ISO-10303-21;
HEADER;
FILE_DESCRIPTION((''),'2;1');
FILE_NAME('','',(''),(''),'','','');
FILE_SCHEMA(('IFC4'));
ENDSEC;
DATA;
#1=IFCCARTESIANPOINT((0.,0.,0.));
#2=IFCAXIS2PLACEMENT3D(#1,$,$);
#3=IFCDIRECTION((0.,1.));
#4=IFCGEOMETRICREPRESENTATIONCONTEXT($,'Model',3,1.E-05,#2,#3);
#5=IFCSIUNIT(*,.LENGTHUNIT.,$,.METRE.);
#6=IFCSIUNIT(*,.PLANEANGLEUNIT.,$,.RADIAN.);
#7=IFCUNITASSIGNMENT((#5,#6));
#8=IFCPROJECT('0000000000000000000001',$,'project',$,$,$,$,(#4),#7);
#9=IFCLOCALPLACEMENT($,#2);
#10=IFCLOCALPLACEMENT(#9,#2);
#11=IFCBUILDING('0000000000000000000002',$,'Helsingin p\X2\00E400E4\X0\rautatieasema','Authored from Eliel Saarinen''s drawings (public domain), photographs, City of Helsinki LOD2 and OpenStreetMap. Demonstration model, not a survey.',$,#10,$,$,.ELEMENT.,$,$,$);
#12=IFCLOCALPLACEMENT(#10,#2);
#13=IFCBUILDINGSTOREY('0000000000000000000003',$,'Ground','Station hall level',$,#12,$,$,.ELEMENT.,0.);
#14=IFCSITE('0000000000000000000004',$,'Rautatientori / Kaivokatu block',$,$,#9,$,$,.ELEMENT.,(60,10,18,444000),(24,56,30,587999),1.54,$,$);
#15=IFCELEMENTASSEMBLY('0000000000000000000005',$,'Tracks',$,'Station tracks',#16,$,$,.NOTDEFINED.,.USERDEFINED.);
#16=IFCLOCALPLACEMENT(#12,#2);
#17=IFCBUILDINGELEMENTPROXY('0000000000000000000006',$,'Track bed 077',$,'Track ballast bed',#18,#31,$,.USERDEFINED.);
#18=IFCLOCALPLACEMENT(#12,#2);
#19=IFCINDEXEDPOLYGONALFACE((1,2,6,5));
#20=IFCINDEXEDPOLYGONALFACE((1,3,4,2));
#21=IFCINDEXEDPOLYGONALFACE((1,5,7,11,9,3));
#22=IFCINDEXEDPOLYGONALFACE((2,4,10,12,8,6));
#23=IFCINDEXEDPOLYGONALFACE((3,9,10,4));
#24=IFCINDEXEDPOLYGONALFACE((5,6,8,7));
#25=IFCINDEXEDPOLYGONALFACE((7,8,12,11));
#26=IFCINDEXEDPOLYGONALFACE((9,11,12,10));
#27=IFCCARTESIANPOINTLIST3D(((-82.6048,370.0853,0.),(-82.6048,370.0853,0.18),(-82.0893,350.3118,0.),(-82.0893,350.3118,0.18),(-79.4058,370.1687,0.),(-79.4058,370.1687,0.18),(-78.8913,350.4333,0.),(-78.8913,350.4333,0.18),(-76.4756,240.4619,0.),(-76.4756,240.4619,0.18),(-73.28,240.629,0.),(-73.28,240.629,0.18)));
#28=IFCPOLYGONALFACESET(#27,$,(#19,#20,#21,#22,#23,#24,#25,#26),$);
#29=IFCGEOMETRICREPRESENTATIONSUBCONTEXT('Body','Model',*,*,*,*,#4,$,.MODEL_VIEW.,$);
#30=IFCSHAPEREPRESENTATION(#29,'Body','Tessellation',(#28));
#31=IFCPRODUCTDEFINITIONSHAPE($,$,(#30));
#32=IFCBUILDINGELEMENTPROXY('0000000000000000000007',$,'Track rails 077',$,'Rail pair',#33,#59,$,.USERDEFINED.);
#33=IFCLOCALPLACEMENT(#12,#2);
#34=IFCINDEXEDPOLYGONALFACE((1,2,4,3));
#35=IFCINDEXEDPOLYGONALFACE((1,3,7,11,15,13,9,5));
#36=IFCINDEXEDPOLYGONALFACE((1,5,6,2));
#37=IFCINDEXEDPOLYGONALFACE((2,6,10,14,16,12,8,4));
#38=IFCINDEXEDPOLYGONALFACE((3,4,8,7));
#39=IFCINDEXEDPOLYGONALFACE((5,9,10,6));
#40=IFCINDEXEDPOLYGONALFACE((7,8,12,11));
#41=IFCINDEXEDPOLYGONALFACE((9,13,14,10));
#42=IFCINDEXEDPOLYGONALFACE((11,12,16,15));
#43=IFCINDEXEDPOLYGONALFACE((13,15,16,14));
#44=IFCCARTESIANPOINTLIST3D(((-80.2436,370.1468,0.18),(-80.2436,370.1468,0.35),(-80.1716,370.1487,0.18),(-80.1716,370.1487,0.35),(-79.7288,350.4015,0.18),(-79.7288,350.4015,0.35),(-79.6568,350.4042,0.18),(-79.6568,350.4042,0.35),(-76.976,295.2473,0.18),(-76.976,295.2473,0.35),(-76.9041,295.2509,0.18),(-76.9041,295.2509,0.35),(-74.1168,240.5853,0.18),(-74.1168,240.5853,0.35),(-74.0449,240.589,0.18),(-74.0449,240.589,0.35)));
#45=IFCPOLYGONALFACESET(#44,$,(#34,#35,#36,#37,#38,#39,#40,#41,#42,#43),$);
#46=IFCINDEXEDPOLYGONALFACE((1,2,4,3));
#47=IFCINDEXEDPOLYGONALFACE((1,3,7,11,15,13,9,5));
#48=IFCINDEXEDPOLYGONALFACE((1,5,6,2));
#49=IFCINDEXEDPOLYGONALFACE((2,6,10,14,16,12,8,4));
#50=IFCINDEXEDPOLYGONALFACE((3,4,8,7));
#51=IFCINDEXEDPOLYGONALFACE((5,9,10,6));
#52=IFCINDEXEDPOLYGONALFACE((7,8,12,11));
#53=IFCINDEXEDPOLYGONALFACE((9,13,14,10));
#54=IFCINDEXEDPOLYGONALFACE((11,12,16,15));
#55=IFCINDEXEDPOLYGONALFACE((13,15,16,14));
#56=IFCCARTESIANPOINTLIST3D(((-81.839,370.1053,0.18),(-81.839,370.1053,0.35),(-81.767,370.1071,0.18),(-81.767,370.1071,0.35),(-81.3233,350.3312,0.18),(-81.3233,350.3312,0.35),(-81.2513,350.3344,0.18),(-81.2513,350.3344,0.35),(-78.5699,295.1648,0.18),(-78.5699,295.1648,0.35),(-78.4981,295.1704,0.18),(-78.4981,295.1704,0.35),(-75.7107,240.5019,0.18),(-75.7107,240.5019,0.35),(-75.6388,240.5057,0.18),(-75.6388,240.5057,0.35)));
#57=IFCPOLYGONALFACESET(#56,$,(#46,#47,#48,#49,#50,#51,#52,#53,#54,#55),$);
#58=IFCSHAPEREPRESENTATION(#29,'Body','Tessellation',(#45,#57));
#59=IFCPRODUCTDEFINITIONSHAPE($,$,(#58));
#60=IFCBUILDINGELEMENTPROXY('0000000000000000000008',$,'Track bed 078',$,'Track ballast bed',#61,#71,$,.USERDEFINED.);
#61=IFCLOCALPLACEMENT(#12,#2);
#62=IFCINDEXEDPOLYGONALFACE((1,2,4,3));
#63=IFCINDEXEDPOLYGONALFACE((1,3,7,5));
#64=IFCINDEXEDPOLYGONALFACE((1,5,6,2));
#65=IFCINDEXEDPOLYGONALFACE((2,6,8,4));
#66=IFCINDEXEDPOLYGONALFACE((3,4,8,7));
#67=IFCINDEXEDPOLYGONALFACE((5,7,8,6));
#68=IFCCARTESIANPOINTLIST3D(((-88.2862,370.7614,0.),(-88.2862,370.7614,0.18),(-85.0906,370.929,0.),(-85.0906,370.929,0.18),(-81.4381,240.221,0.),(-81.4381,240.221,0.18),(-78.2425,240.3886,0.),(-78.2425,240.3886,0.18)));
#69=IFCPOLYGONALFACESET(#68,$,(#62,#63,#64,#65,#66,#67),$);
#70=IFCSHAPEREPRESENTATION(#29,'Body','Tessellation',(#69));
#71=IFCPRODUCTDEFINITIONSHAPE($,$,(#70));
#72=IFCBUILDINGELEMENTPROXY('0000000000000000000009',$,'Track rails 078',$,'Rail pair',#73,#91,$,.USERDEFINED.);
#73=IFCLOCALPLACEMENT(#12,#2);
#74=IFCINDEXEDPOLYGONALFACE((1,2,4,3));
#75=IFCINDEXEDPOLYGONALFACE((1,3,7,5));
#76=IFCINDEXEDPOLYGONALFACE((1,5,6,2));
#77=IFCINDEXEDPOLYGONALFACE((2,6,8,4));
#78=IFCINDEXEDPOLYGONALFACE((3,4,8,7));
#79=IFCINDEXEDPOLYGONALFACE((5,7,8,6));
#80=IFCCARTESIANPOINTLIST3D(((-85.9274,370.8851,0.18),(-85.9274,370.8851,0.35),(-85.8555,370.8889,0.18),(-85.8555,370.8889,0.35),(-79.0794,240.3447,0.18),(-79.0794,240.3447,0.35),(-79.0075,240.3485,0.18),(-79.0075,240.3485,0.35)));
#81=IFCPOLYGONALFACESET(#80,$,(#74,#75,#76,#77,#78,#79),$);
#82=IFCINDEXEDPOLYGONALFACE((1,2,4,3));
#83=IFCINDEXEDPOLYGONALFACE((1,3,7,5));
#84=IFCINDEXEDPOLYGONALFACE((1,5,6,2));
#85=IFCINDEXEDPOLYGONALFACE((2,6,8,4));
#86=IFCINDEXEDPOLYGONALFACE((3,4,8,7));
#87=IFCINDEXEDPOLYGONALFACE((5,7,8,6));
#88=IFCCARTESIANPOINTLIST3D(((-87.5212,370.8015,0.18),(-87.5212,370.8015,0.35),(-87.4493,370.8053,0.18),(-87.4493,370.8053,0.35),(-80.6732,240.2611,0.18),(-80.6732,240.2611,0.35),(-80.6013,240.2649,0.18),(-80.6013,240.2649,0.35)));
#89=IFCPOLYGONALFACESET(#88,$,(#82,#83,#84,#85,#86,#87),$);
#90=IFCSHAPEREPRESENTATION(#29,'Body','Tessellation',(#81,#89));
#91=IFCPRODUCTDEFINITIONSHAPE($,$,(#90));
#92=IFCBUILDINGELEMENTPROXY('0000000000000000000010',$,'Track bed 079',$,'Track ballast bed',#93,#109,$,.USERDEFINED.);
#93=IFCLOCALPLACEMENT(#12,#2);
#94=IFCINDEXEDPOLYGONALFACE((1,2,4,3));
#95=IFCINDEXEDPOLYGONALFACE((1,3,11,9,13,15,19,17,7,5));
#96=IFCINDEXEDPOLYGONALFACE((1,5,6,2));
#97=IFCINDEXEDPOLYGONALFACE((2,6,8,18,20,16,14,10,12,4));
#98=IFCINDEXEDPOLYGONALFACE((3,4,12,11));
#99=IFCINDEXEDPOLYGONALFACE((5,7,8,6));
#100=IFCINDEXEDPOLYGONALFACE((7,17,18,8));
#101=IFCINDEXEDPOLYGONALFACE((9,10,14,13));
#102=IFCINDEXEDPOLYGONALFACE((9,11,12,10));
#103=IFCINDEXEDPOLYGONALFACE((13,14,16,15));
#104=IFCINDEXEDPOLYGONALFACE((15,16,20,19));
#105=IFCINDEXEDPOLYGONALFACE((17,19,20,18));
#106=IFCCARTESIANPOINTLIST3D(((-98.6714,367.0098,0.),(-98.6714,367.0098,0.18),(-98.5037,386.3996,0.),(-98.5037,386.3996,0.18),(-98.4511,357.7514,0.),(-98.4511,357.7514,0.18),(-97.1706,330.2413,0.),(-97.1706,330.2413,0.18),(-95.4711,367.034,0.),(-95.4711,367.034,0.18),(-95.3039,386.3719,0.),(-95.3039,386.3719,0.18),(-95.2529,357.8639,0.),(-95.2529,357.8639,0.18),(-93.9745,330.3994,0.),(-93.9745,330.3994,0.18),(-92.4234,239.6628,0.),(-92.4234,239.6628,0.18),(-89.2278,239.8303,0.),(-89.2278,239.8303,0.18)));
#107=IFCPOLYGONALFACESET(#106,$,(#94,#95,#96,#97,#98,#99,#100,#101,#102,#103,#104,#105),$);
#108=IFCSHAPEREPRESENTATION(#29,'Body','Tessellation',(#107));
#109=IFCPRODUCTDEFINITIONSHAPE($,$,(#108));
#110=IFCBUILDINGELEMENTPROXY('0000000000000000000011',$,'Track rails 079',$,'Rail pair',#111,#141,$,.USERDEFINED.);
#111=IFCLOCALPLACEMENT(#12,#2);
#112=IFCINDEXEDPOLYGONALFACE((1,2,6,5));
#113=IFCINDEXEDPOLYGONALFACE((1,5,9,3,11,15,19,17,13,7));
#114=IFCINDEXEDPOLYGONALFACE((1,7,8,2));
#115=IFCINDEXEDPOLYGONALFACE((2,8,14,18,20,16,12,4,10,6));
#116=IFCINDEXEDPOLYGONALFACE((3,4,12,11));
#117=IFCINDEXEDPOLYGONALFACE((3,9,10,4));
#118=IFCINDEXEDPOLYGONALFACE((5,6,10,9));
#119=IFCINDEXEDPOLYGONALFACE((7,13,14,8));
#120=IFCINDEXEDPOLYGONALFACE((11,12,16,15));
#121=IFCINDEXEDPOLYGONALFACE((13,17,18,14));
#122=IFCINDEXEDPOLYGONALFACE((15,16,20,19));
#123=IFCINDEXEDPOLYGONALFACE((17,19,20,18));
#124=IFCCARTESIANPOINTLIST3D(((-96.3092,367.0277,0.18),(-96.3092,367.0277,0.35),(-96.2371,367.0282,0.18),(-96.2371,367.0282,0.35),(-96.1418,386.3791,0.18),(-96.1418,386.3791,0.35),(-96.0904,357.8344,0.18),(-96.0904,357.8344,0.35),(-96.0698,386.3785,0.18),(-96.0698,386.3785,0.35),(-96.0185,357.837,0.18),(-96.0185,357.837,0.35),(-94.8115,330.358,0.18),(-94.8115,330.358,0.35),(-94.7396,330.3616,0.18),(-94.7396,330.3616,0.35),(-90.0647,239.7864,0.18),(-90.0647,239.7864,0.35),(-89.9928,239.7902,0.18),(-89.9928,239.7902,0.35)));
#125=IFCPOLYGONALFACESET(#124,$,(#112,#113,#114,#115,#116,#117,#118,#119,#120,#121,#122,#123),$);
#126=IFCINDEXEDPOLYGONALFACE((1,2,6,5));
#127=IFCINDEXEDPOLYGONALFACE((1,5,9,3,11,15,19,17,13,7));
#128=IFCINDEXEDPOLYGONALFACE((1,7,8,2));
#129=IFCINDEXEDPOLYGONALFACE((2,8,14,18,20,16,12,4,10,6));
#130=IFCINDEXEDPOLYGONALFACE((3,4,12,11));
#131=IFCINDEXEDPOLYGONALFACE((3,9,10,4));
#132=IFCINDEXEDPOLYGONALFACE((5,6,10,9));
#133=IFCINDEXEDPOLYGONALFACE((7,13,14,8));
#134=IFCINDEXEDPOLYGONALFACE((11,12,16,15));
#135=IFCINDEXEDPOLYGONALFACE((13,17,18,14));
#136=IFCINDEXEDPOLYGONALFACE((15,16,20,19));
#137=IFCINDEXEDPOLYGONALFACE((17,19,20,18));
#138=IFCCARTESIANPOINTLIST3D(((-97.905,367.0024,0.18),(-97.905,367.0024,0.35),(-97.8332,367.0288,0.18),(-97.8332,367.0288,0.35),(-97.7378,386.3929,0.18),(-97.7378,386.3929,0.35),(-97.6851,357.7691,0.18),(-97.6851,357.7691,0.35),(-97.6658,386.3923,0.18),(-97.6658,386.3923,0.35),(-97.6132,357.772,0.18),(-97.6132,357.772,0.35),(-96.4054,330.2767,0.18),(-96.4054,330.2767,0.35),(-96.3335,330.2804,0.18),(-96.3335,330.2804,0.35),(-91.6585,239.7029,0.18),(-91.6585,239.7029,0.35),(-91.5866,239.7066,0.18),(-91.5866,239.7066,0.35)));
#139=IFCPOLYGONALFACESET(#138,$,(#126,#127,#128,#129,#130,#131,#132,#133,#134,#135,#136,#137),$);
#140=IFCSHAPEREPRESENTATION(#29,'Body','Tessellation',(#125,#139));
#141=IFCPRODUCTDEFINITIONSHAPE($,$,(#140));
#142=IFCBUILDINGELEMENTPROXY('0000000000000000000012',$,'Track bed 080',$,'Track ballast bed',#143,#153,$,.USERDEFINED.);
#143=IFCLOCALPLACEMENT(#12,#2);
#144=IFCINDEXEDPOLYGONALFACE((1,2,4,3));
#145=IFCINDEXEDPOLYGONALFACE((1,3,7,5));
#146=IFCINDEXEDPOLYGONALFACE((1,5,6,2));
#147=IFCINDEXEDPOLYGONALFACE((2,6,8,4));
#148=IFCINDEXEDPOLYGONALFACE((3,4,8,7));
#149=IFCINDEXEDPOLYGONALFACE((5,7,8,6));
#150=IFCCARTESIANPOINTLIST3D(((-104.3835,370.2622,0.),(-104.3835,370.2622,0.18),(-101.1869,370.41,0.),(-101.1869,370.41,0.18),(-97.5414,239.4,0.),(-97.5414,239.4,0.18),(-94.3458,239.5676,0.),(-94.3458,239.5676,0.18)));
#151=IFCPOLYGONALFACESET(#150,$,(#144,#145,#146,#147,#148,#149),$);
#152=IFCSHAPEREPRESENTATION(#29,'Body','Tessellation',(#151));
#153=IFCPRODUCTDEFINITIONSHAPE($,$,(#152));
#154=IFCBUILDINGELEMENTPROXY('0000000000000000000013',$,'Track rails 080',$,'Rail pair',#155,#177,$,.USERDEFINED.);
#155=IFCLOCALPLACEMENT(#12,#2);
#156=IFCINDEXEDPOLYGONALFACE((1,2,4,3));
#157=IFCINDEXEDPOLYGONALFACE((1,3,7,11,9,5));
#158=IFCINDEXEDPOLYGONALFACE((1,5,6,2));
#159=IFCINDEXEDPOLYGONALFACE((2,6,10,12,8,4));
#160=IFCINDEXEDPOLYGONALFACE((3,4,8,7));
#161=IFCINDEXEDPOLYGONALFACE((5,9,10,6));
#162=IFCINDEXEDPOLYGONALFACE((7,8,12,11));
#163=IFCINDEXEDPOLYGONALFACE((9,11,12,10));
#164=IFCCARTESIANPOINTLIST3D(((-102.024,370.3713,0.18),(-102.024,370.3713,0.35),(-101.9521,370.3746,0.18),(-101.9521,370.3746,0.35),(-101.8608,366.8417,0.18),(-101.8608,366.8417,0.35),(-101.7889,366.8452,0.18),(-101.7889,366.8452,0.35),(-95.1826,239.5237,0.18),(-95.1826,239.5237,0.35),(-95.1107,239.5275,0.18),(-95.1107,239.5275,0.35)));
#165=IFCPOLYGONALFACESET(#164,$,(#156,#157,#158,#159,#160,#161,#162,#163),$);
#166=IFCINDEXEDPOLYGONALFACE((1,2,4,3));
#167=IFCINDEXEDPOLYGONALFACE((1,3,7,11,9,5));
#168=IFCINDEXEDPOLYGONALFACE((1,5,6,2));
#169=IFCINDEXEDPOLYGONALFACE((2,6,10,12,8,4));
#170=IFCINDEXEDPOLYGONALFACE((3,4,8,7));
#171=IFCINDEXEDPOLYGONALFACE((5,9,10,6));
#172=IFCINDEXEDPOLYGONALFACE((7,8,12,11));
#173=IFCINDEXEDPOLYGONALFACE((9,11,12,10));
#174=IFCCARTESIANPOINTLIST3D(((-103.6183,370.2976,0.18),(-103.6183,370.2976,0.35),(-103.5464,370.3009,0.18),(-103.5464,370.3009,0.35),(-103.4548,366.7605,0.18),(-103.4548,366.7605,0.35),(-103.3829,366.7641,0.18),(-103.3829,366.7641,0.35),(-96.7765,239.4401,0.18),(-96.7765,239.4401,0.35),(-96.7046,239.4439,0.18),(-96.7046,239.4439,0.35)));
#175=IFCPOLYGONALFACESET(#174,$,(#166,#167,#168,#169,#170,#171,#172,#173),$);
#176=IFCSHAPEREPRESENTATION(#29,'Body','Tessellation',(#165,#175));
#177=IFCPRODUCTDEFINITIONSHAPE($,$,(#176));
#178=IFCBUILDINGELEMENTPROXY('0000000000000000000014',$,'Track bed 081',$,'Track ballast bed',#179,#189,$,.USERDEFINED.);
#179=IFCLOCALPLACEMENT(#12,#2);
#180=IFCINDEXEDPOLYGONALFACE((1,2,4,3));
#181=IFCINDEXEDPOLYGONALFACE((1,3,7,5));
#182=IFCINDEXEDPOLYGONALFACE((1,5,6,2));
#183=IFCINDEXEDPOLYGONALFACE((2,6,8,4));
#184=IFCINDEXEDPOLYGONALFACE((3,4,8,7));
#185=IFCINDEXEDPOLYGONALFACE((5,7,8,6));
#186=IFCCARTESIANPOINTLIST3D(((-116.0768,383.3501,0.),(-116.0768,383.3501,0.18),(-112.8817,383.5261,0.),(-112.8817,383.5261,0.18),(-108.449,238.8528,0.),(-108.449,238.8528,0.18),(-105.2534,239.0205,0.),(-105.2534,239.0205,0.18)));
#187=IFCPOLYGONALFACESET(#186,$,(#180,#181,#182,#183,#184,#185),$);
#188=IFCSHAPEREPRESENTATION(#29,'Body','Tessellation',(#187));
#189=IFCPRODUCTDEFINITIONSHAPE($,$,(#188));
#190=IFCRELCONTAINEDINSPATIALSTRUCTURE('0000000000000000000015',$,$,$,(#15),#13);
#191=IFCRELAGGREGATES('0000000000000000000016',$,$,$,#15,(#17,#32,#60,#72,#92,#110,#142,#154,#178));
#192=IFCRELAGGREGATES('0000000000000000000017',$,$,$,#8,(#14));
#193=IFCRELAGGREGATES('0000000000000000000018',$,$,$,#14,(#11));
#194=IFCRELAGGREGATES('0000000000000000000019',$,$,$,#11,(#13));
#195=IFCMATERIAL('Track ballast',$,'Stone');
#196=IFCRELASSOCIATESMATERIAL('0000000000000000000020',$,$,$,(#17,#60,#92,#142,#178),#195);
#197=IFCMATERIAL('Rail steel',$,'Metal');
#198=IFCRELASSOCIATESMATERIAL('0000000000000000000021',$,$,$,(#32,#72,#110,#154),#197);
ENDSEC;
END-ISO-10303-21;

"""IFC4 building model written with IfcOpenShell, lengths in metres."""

from ifc_helpers import new_model, si_unit, direction, frame, origin, place, context, subcontext, project, spatial, polyline, outline, extrude, material, element, aggregate, save


model = new_model("IFC4")

# Units and contexts
model_context = context("Model", 3, precision=1e-05, world=origin(), true_north=direction((0.0, 1.0)))
body_context = subcontext(model_context, "Body", "Model", "MODEL_VIEW")
ifc_project = project(units=[si_unit("LENGTHUNIT", "METRE"), si_unit("PLANEANGLEUNIT", "RADIAN")], contexts=[model_context])

# Site, building, storey
site_placement = place(None, origin())
site = spatial("IfcSite", under=ifc_project, at=site_placement, Name="Rautatientori / Kaivokatu block", CompositionType="ELEMENT", RefLatitude=(60, 10, 18, 444000), RefLongitude=(24, 56, 30, 587999), RefElevation=1.54)
building_placement = place(site_placement, origin())
building = spatial("IfcBuilding", under=site, at=building_placement, Name="Helsingin päärautatieasema", Description="Authored from Eliel Saarinen's drawings (public domain), photographs, City of Helsinki LOD2 and OpenStreetMap. Demonstration model, not a survey.", CompositionType="ELEMENT")
storey_placement = place(building_placement, origin())
storey = spatial("IfcBuildingStorey", under=building, at=storey_placement, Name="Ground", Description="Station hall level", CompositionType="ELEMENT", Elevation=0.0)

# Element assembly, building element proxies
assembly_placement = place(building_placement, origin())
assembly = element("IfcElementAssembly", 1, at=assembly_placement, inside=storey, Name="Tracks", ObjectType="Station tracks", AssemblyPlace="NOTDEFINED", PredefinedType="USERDEFINED")
ifc_material_1 = material(Name="Track ballast", Category="Stone")
proxy_1_placement = place(building_placement, origin())
proxy_1 = element("IfcBuildingElementProxy", 2, at=proxy_1_placement, material=ifc_material_1, Name="Track bed 077", ObjectType="Track ballast bed", PredefinedType="USERDEFINED", context=body_context, shape_type="SweptSolid", body=[
    extrude(outline(polyline([(-76.4756, 240.4619), (-82.0893, 350.3118), (-82.6048, 370.0853), (-79.4058, 370.1687), (-78.8913, 350.4333), (-73.28, 240.629), (-76.4756, 240.4619)])), origin(), (0.0, 0.0, 1.0), 0.18),
])
ifc_material_2 = material(Name="Rail steel", Category="Metal")
proxy_2_placement = place(building_placement, origin())
proxy_2 = element("IfcBuildingElementProxy", 3, at=proxy_2_placement, material=ifc_material_2, Name="Track rails 077", ObjectType="Rail pair", PredefinedType="USERDEFINED", context=body_context, shape_type="SweptSolid", body=[
    extrude(outline(polyline([(-76.976, 295.2473), (-79.7288, 350.4015), (-80.2436, 370.1468), (-80.1716, 370.1487), (-79.6568, 350.4042), (-76.9041, 295.2509), (-74.0449, 240.589), (-74.1168, 240.5853), (-76.976, 295.2473)])), frame((0.0, 0.0, 0.18)), (0.0, 0.0, 1.0), 0.17),
    extrude(outline(polyline([(-78.5699, 295.1648), (-81.3233, 350.3312), (-81.839, 370.1053), (-81.767, 370.1071), (-81.2513, 350.3344), (-78.4981, 295.1704), (-75.6388, 240.5057), (-75.7107, 240.5019), (-78.5699, 295.1648)])), frame((0.0, 0.0, 0.18)), (0.0, 0.0, 1.0), 0.17),
])
proxy_3_placement = place(building_placement, origin())
proxy_3 = element("IfcBuildingElementProxy", 4, at=proxy_3_placement, material=ifc_material_1, Name="Track bed 078", ObjectType="Track ballast bed", PredefinedType="USERDEFINED", context=body_context, shape_type="SweptSolid", body=[
    extrude(outline(polyline([(-88.2862, 370.7614), (-85.0906, 370.929), (-78.2425, 240.3886), (-81.4381, 240.221), (-88.2862, 370.7614)])), origin(), (0.0, 0.0, 1.0), 0.18),
])
proxy_4_placement = place(building_placement, origin())
proxy_4 = element("IfcBuildingElementProxy", 5, at=proxy_4_placement, material=ifc_material_2, Name="Track rails 078", ObjectType="Rail pair", PredefinedType="USERDEFINED", context=body_context, shape_type="SweptSolid", body=[
    extrude(outline(polyline([(-85.9274, 370.8851), (-85.8555, 370.8889), (-79.0075, 240.3485), (-79.0794, 240.3447), (-85.9274, 370.8851)])), frame((0.0, 0.0, 0.18)), (0.0, 0.0, 1.0), 0.17),
    extrude(outline(polyline([(-87.5212, 370.8015), (-87.4493, 370.8053), (-80.6013, 240.2649), (-80.6732, 240.2611), (-87.5212, 370.8015)])), frame((0.0, 0.0, 0.18)), (0.0, 0.0, 1.0), 0.17),
])
proxy_5_placement = place(building_placement, origin())
proxy_5 = element("IfcBuildingElementProxy", 6, at=proxy_5_placement, material=ifc_material_1, Name="Track bed 079", ObjectType="Track ballast bed", PredefinedType="USERDEFINED", context=body_context, shape_type="SweptSolid", body=[
    extrude(outline(polyline([(-97.1706, 330.2413), (-98.4511, 357.7514), (-98.6714, 367.0098), (-98.5037, 386.3996), (-95.3039, 386.3719), (-95.4711, 367.034), (-95.2529, 357.8639), (-93.9745, 330.3994), (-89.2278, 239.8303), (-92.4234, 239.6628), (-97.1706, 330.2413)])), origin(), (0.0, 0.0, 1.0), 0.18),
])
proxy_6_placement = place(building_placement, origin())
proxy_6 = element("IfcBuildingElementProxy", 7, at=proxy_6_placement, material=ifc_material_2, Name="Track rails 079", ObjectType="Rail pair", PredefinedType="USERDEFINED", context=body_context, shape_type="SweptSolid", body=[
    extrude(outline(polyline([(-94.8115, 330.358), (-96.0904, 357.8344), (-96.3092, 367.0277), (-96.1418, 386.3791), (-96.0698, 386.3785), (-96.2371, 367.0282), (-96.0185, 357.837), (-94.7396, 330.3616), (-89.9928, 239.7902), (-90.0647, 239.7864), (-94.8115, 330.358)])), frame((0.0, 0.0, 0.18)), (0.0, 0.0, 1.0), 0.17),
    extrude(outline(polyline([(-96.4054, 330.2767), (-97.6851, 357.7691), (-97.905, 367.0024), (-97.7378, 386.3929), (-97.6658, 386.3923), (-97.8332, 367.0288), (-97.6132, 357.772), (-96.3335, 330.2804), (-91.5866, 239.7066), (-91.6585, 239.7029), (-96.4054, 330.2767)])), frame((0.0, 0.0, 0.18)), (0.0, 0.0, 1.0), 0.17),
])
proxy_7_placement = place(building_placement, origin())
proxy_7 = element("IfcBuildingElementProxy", 8, at=proxy_7_placement, material=ifc_material_1, Name="Track bed 080", ObjectType="Track ballast bed", PredefinedType="USERDEFINED", context=body_context, shape_type="SweptSolid", body=[
    extrude(outline(polyline([(-97.5414, 239.4), (-104.3835, 370.2622), (-101.1869, 370.41), (-94.3458, 239.5676), (-97.5414, 239.4)])), origin(), (0.0, 0.0, 1.0), 0.18),
])
proxy_8_placement = place(building_placement, origin())
proxy_8 = element("IfcBuildingElementProxy", 9, at=proxy_8_placement, material=ifc_material_2, Name="Track rails 080", ObjectType="Rail pair", PredefinedType="USERDEFINED", context=body_context, shape_type="SweptSolid", body=[
    extrude(outline(polyline([(-101.8608, 366.8417), (-102.024, 370.3713), (-101.9521, 370.3746), (-101.7889, 366.8452), (-95.1107, 239.5275), (-95.1826, 239.5237), (-101.8608, 366.8417)])), frame((0.0, 0.0, 0.18)), (0.0, 0.0, 1.0), 0.17),
    extrude(outline(polyline([(-103.4548, 366.7605), (-103.6183, 370.2976), (-103.5464, 370.3009), (-103.3829, 366.7641), (-96.7046, 239.4439), (-96.7765, 239.4401), (-103.4548, 366.7605)])), frame((0.0, 0.0, 0.18)), (0.0, 0.0, 1.0), 0.17),
])
proxy_9_placement = place(building_placement, origin())
proxy_9 = element("IfcBuildingElementProxy", 10, at=proxy_9_placement, material=ifc_material_1, Name="Track bed 081", ObjectType="Track ballast bed", PredefinedType="USERDEFINED", context=body_context, shape_type="SweptSolid", body=[
    extrude(outline(polyline([(-108.449, 238.8528), (-116.0768, 383.3501), (-112.8817, 383.5261), (-105.2534, 239.0205), (-108.449, 238.8528)])), origin(), (0.0, 0.0, 1.0), 0.18),
])
aggregate(assembly, [proxy_1, proxy_2, proxy_3, proxy_4, proxy_5, proxy_6, proxy_7, proxy_8, proxy_9])

save(model, "model.ifc")
